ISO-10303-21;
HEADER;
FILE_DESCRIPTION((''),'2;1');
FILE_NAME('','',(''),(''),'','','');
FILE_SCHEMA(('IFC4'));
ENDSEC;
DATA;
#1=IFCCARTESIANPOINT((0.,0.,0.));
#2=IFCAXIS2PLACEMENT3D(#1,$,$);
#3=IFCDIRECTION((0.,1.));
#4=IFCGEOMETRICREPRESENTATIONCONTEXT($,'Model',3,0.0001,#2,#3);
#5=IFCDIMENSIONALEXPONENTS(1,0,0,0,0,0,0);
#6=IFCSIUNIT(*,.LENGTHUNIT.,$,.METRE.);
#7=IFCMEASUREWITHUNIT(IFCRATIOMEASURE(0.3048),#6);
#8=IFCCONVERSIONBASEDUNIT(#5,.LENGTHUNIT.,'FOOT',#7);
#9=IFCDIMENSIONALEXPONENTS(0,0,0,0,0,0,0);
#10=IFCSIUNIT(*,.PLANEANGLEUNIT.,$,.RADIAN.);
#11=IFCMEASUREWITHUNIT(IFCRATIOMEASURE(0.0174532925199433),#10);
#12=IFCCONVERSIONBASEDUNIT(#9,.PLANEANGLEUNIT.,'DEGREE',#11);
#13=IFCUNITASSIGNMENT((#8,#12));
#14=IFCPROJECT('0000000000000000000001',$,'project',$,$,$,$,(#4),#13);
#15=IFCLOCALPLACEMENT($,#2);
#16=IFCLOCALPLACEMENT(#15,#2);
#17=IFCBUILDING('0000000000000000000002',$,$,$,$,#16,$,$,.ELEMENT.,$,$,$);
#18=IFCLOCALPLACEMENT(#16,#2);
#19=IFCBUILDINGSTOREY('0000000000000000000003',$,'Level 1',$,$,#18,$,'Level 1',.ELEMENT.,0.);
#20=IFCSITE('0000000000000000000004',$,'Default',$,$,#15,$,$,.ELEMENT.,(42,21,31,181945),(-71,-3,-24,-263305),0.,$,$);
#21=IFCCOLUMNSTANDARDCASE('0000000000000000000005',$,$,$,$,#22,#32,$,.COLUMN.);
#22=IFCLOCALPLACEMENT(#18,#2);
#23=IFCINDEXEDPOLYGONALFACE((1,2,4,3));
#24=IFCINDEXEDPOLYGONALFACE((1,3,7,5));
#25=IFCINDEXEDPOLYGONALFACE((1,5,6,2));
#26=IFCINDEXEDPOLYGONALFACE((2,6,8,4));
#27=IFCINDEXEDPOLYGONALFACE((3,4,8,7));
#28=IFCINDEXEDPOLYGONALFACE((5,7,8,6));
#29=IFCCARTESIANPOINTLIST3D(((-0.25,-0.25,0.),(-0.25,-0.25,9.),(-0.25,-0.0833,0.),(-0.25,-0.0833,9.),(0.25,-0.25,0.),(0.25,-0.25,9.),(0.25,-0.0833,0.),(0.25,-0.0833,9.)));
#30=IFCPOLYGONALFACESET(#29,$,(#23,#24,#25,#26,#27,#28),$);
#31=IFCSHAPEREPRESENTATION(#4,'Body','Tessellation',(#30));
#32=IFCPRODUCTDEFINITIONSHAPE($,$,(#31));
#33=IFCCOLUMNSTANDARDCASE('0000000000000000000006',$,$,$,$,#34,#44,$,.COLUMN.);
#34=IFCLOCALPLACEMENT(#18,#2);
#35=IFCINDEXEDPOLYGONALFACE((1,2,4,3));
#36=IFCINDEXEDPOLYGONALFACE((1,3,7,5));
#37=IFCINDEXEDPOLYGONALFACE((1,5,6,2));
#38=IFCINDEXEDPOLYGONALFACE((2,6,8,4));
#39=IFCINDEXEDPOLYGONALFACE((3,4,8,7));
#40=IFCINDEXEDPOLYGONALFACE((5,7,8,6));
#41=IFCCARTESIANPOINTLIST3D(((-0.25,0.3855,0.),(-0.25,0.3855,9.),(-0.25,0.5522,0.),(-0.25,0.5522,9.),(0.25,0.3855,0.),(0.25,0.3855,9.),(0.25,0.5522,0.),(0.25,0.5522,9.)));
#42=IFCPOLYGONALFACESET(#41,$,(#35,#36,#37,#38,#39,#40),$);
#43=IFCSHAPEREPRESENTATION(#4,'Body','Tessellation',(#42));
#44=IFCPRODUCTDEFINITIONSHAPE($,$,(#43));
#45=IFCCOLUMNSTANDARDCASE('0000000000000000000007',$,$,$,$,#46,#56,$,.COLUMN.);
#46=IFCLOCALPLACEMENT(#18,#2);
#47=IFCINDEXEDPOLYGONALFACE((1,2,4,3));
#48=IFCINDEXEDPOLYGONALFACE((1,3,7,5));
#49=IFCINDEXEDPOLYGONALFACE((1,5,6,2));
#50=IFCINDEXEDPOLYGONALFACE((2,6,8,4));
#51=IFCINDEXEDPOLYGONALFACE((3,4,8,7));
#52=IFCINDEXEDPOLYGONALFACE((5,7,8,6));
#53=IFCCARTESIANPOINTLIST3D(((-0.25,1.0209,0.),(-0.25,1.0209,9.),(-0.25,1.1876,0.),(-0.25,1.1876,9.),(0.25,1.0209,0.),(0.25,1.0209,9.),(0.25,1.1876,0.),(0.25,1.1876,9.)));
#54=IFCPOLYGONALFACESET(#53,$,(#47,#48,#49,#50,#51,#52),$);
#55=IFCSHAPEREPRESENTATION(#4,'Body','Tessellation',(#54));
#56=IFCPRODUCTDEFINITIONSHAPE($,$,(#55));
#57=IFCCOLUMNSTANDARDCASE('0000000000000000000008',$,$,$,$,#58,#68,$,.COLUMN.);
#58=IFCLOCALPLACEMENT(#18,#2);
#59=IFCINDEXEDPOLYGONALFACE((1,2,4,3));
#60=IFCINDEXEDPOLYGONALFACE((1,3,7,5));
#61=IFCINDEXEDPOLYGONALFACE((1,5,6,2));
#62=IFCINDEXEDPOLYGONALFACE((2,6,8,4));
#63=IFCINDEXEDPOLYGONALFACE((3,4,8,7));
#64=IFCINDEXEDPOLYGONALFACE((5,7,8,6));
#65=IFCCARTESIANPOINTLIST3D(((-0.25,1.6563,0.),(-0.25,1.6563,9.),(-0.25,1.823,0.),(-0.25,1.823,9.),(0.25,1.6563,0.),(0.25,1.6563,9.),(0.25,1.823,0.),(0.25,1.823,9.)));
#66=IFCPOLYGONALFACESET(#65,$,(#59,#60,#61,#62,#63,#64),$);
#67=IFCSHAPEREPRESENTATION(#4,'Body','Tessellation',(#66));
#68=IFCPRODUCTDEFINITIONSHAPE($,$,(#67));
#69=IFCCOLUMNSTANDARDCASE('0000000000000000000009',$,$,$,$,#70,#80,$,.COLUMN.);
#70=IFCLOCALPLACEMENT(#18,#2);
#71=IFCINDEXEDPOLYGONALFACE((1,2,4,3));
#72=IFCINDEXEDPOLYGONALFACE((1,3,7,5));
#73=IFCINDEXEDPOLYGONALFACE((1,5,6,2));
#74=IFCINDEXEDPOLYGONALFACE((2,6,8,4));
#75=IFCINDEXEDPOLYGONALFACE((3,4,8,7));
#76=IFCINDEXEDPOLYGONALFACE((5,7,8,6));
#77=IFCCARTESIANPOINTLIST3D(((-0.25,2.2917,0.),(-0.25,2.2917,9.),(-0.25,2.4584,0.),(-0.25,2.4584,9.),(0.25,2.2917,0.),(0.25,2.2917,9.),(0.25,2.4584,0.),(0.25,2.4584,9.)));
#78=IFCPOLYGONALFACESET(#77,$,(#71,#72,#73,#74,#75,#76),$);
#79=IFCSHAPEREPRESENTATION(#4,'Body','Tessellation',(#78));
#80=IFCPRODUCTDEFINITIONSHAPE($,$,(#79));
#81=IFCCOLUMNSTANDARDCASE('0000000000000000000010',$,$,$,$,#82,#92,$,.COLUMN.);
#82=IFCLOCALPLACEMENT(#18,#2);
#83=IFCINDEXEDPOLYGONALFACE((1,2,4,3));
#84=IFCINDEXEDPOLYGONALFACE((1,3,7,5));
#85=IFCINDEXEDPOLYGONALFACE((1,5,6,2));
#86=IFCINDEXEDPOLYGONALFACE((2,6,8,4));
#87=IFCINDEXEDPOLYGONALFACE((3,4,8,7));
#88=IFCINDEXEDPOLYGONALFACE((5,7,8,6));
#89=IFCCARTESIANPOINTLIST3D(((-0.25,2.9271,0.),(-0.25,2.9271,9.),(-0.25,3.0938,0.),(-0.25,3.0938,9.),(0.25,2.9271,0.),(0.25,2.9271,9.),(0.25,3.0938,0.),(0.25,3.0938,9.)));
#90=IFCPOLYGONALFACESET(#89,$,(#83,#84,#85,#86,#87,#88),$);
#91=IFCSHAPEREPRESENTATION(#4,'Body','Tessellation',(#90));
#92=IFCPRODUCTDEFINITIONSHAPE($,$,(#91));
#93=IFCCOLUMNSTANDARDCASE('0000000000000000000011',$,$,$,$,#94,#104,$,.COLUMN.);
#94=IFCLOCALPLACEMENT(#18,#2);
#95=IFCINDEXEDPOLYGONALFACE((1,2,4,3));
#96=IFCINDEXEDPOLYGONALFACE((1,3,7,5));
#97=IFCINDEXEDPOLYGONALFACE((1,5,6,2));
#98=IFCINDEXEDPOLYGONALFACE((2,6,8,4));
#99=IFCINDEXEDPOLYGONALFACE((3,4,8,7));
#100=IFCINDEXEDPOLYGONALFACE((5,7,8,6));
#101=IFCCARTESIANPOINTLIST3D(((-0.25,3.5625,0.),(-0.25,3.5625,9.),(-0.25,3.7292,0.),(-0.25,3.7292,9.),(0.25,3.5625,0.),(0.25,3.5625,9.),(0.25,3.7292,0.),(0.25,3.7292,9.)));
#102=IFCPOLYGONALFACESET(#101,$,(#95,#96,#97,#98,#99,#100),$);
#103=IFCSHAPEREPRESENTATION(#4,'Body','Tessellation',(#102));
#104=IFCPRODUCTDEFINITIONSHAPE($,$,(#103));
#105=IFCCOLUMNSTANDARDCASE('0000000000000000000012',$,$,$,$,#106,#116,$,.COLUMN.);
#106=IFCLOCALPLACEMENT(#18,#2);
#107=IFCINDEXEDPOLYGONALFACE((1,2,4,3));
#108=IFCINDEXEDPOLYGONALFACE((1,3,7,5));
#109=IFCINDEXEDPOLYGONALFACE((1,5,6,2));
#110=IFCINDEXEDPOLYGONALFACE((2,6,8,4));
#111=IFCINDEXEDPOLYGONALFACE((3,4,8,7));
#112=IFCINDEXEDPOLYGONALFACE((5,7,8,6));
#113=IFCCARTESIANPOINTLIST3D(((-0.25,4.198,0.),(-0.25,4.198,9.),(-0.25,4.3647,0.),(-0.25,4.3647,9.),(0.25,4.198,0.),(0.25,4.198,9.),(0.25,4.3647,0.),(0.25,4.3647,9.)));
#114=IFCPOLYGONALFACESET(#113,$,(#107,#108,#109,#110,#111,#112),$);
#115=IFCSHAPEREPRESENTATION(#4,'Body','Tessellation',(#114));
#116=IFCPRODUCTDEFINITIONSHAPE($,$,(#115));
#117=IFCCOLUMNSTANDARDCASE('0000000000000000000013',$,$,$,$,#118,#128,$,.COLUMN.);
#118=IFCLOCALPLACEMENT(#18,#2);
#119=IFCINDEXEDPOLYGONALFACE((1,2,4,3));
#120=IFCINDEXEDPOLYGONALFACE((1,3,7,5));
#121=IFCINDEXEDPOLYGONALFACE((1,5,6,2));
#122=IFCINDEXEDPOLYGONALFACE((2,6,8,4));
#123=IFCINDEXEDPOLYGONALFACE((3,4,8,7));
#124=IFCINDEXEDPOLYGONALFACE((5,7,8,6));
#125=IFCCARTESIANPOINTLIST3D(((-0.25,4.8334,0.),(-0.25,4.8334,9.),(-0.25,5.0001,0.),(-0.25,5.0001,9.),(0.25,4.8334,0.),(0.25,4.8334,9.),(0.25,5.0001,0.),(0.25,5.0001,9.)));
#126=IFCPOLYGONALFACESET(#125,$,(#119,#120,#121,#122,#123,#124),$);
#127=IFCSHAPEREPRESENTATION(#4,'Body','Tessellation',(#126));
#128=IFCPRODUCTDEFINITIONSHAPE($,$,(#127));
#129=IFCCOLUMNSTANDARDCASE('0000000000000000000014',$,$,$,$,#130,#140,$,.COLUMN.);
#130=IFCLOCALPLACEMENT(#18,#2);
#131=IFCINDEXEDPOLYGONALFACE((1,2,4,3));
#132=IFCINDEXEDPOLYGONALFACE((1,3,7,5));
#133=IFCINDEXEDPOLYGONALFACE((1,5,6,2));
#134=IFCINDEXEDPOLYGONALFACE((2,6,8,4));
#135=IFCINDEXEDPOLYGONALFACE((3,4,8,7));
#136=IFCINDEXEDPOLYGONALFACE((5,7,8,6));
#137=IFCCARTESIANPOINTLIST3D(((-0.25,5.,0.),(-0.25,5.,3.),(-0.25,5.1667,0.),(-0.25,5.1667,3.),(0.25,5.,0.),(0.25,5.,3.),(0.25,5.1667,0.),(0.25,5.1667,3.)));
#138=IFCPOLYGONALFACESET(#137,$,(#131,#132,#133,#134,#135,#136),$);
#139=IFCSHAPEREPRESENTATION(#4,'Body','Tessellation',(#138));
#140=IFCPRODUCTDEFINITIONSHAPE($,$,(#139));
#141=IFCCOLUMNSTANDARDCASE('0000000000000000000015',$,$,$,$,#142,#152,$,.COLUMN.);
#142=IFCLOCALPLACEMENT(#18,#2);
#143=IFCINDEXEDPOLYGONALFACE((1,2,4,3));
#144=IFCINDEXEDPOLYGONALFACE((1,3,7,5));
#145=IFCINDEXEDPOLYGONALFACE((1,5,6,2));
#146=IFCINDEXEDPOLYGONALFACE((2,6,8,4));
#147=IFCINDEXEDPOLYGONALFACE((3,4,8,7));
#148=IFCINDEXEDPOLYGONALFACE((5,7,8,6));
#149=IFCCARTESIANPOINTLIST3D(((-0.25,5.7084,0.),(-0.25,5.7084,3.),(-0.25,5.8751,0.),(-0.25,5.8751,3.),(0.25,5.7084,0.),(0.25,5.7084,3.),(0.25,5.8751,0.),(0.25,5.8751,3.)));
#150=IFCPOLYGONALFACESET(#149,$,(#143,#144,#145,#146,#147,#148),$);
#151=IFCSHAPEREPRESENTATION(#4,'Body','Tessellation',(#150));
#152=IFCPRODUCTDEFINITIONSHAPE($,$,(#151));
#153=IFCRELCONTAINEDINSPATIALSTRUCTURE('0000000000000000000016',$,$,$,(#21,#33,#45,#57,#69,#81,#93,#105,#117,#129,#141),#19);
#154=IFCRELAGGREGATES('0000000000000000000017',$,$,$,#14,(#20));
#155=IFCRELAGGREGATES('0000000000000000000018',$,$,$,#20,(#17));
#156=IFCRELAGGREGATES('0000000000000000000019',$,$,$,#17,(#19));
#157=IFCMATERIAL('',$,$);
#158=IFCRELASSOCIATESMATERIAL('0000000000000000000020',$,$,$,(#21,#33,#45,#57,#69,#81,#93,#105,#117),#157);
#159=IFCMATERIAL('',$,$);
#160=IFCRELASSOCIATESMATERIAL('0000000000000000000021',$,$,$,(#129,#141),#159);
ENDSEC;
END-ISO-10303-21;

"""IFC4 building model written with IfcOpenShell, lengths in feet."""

from ifc_helpers import new_model, entity, si_unit, converted_unit, direction, frame, origin, place, context, project, spatial, rectangle, extrude, material, element, save


model = new_model("IFC4")

# Units and contexts
model_context = context("Model", 3, precision=0.0001, world=origin(), true_north=direction((0.0, 1.0)))
ifc_project = project(units=[converted_unit("LENGTHUNIT", "FOOT", entity("IfcRatioMeasure", 0.3048), si_unit("LENGTHUNIT", "METRE"), dimensions=[1, 0, 0, 0, 0, 0, 0]), converted_unit("PLANEANGLEUNIT", "DEGREE", entity("IfcRatioMeasure", 0.0174532925199433), si_unit("PLANEANGLEUNIT", "RADIAN"), dimensions=[0, 0, 0, 0, 0, 0, 0])], contexts=[model_context])

# Site, building, storey
site_placement = place(None, origin())
site = spatial("IfcSite", under=ifc_project, at=site_placement, Name="Default", CompositionType="ELEMENT", RefLatitude=(42, 21, 31, 181945), RefLongitude=(-71, -3, -24, -263305), RefElevation=0.0)
building_placement = place(site_placement, origin())
building = spatial("IfcBuilding", under=site, at=building_placement, CompositionType="ELEMENT")
storey_placement = place(building_placement, origin())
storey = spatial("IfcBuildingStorey", under=building, at=storey_placement, Name="Level 1", LongName="Level 1", CompositionType="ELEMENT", Elevation=0.0)

# Columns
ifc_material_1 = material(Name="")
placement_1 = place(storey_placement, frame((0.0, -0.25, 0.0), z_axis=(0.0, 0.0, 1.0), x_axis=(0.0, 1.0, 0.0)))
for number, where, z_axis, x_axis in (
    (1, (0.0833, 0.0, 0.0), (0.0, 0.0, 1.0), (1.0, 0.0, 0.0)),
    (2, (0.7188, 0.0, 0.0), (0.0, 0.0, 1.0), (1.0, 0.0, 0.0)),
    (3, (1.3542, 0.0, 0.0), (0.0, 0.0, 1.0), (1.0, 0.0, 0.0)),
    (4, (1.9896, 0.0, 0.0), (0.0, 0.0, 1.0), (1.0, 0.0, 0.0)),
    (5, (2.625, 0.0, 0.0), (0.0, 0.0, 1.0), (1.0, 0.0, 0.0)),
    (6, (3.2604, 0.0, 0.0), (0.0, 0.0, 1.0), (1.0, 0.0, 0.0)),
    (7, (3.8958, 0.0, 0.0), (0.0, 0.0, 1.0), (1.0, 0.0, 0.0)),
    (8, (4.5313, 0.0, 0.0), (0.0, 0.0, 1.0), (1.0, 0.0, 0.0)),
    (9, (5.1667, 0.0, 0.0), (0.0, 0.0, 1.0), (1.0, 0.0, 0.0)),
):
    element("IfcColumnStandardCase", number, at=place(placement_1, frame(where, z_axis=z_axis, x_axis=x_axis)), inside=storey, material=ifc_material_1, PredefinedType="COLUMN", context=model_context, shape_type="SweptSolid", body=[
        extrude(rectangle(XDim=0.1667, YDim=0.5), origin(), (0.0, 0.0, 1.0), 9.0),
    ])
ifc_material_2 = material(Name="")
for number, where, z_axis, x_axis in (
    (10, (5.3333, 0.0, 0.0), (0.0, 0.0, 1.0), (1.0, 0.0, 0.0)),
    (11, (6.0417, 0.0, 0.0), (0.0, 0.0, 1.0), (1.0, 0.0, 0.0)),
):
    element("IfcColumnStandardCase", number, at=place(placement_1, frame(where, z_axis=z_axis, x_axis=x_axis)), inside=storey, material=ifc_material_2, PredefinedType="COLUMN", context=model_context, shape_type="SweptSolid", body=[
        extrude(rectangle(XDim=0.1667, YDim=0.5), origin(), (0.0, 0.0, 1.0), 3.0),
    ])

save(model, "model.ifc")
